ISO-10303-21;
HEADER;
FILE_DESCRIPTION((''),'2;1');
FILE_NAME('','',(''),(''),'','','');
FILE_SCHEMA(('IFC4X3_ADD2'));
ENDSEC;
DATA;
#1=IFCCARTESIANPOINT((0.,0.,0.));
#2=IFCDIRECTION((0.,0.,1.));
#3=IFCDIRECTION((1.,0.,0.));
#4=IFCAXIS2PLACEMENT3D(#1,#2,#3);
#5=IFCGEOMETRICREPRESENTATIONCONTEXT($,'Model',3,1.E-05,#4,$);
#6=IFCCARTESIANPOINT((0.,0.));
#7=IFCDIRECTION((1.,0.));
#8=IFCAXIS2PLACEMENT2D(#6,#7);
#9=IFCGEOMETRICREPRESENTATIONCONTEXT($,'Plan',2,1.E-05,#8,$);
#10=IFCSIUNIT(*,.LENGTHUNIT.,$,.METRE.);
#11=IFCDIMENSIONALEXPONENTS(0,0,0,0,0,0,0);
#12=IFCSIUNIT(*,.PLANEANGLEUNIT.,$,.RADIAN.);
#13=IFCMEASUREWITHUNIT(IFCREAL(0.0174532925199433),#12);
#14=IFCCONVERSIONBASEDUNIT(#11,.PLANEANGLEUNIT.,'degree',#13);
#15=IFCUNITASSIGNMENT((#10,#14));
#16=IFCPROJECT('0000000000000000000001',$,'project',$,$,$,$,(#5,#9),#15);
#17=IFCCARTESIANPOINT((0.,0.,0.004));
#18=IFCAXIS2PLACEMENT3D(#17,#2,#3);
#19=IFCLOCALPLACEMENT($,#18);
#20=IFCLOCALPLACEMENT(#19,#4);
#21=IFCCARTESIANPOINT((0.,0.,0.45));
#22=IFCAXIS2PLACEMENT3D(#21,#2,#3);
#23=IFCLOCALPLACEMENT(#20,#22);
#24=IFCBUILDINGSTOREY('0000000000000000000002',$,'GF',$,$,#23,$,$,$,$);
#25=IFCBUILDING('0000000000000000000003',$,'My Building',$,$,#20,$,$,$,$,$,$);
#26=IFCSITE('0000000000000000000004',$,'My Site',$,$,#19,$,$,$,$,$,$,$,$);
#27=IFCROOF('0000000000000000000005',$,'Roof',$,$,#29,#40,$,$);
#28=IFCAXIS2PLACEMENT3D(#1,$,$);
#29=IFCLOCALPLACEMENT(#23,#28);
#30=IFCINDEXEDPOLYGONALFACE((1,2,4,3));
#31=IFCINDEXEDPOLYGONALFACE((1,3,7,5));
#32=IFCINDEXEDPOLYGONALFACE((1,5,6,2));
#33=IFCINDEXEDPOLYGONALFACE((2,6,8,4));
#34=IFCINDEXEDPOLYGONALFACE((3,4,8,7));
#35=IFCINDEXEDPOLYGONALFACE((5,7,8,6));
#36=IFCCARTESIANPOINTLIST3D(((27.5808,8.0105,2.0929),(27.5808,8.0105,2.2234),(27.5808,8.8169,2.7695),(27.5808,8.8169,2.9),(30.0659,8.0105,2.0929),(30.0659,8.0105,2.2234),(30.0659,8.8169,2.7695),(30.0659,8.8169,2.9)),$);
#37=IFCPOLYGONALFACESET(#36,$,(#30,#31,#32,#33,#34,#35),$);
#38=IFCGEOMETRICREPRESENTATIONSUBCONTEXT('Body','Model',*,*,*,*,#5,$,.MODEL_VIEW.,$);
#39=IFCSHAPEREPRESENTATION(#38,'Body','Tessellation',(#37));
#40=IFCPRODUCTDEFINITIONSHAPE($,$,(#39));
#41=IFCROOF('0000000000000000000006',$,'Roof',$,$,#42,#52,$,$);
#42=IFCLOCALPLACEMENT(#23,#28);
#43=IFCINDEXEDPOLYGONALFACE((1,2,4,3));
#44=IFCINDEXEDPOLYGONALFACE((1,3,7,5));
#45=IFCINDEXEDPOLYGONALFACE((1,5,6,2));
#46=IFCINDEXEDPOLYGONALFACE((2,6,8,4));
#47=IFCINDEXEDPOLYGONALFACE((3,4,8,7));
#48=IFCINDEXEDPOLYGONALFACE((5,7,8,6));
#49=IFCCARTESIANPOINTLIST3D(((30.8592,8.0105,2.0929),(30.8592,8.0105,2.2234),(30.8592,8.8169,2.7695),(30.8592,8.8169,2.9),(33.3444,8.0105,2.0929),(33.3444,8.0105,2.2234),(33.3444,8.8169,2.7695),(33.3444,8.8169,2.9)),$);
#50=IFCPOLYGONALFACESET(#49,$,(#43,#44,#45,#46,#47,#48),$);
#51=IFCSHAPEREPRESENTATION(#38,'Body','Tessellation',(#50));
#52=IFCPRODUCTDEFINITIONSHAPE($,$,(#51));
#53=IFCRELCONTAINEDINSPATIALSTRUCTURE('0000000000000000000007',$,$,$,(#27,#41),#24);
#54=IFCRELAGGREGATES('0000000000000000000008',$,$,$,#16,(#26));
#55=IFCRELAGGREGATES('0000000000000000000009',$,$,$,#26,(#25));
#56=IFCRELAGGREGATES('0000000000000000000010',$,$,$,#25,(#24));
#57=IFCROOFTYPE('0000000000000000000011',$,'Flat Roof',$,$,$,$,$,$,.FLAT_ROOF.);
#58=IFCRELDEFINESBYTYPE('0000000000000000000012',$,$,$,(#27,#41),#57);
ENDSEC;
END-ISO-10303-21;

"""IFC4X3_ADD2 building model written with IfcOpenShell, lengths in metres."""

from ifc_helpers import new_model, entity, si_unit, converted_unit, frame, origin_with_axes, origin_2d_with_axis, place, context, subcontext, project, spatial, polyline, outline, extrude, type_object, element, save


model = new_model("IFC4X3_ADD2")

# Units and contexts
model_context = context("Model", 3, precision=1e-05, world=origin_with_axes())
plan_context = context("Plan", 2, precision=1e-05, world=origin_2d_with_axis())
body_context = subcontext(model_context, "Body", "Model", "MODEL_VIEW")
ifc_project = project(units=[si_unit("LENGTHUNIT", "METRE"), converted_unit("PLANEANGLEUNIT", "degree", entity("IfcReal", 0.0174532925199433), si_unit("PLANEANGLEUNIT", "RADIAN"), dimensions=[0, 0, 0, 0, 0, 0, 0])], contexts=[model_context, plan_context])

# Site, building, storey
site_placement = place(None, frame((0.0, 0.0, 0.004), z_axis=(0.0, 0.0, 1.0), x_axis=(1.0, 0.0, 0.0)))
site = spatial("IfcSite", under=ifc_project, at=site_placement, Name="My Site")
building_placement = place(site_placement, origin_with_axes())
building = spatial("IfcBuilding", under=site, at=building_placement, Name="My Building")
storey_placement = place(building_placement, frame((0.0, 0.0, 0.45), z_axis=(0.0, 0.0, 1.0), x_axis=(1.0, 0.0, 0.0)))
storey = spatial("IfcBuildingStorey", under=building, at=storey_placement, Name="GF")

# Roofs
roof_type = type_object("IfcRoofType", Name="Flat Roof", PredefinedType="FLAT_ROOF")
for number, where, z_axis, x_axis, name in (
    (1, (27.5808, 8.0241, 2.1043), (0.0, -0.642788, 0.766044), (1.0, 0.0, 0.0), "Roof"),
    (2, (30.8592, 8.0241, 2.1043), (0.0, -0.642788, 0.766044), (1.0, 0.0, 0.0), "Roof"),
):
    element("IfcRoof", number, at=place(storey_placement, frame(where, z_axis=z_axis, x_axis=x_axis)), inside=storey, type_object=roof_type, Name=name, context=body_context, shape_type="SweptSolid", body=[
        extrude(outline(polyline([(-1.2426, -0.0653), (1.2426, -0.0653), (1.2426, 0.0653), (-1.2426, 0.0653), (-1.2426, -0.0653)])), frame((1.2426, 1.0768, 0.05), z_axis=(0.0, 0.766044, -0.642788), x_axis=(1.0, 0.0, 0.0)), (0.0, 0.642788, -0.766044), 1.0526),
    ])

save(model, "model.ifc")
